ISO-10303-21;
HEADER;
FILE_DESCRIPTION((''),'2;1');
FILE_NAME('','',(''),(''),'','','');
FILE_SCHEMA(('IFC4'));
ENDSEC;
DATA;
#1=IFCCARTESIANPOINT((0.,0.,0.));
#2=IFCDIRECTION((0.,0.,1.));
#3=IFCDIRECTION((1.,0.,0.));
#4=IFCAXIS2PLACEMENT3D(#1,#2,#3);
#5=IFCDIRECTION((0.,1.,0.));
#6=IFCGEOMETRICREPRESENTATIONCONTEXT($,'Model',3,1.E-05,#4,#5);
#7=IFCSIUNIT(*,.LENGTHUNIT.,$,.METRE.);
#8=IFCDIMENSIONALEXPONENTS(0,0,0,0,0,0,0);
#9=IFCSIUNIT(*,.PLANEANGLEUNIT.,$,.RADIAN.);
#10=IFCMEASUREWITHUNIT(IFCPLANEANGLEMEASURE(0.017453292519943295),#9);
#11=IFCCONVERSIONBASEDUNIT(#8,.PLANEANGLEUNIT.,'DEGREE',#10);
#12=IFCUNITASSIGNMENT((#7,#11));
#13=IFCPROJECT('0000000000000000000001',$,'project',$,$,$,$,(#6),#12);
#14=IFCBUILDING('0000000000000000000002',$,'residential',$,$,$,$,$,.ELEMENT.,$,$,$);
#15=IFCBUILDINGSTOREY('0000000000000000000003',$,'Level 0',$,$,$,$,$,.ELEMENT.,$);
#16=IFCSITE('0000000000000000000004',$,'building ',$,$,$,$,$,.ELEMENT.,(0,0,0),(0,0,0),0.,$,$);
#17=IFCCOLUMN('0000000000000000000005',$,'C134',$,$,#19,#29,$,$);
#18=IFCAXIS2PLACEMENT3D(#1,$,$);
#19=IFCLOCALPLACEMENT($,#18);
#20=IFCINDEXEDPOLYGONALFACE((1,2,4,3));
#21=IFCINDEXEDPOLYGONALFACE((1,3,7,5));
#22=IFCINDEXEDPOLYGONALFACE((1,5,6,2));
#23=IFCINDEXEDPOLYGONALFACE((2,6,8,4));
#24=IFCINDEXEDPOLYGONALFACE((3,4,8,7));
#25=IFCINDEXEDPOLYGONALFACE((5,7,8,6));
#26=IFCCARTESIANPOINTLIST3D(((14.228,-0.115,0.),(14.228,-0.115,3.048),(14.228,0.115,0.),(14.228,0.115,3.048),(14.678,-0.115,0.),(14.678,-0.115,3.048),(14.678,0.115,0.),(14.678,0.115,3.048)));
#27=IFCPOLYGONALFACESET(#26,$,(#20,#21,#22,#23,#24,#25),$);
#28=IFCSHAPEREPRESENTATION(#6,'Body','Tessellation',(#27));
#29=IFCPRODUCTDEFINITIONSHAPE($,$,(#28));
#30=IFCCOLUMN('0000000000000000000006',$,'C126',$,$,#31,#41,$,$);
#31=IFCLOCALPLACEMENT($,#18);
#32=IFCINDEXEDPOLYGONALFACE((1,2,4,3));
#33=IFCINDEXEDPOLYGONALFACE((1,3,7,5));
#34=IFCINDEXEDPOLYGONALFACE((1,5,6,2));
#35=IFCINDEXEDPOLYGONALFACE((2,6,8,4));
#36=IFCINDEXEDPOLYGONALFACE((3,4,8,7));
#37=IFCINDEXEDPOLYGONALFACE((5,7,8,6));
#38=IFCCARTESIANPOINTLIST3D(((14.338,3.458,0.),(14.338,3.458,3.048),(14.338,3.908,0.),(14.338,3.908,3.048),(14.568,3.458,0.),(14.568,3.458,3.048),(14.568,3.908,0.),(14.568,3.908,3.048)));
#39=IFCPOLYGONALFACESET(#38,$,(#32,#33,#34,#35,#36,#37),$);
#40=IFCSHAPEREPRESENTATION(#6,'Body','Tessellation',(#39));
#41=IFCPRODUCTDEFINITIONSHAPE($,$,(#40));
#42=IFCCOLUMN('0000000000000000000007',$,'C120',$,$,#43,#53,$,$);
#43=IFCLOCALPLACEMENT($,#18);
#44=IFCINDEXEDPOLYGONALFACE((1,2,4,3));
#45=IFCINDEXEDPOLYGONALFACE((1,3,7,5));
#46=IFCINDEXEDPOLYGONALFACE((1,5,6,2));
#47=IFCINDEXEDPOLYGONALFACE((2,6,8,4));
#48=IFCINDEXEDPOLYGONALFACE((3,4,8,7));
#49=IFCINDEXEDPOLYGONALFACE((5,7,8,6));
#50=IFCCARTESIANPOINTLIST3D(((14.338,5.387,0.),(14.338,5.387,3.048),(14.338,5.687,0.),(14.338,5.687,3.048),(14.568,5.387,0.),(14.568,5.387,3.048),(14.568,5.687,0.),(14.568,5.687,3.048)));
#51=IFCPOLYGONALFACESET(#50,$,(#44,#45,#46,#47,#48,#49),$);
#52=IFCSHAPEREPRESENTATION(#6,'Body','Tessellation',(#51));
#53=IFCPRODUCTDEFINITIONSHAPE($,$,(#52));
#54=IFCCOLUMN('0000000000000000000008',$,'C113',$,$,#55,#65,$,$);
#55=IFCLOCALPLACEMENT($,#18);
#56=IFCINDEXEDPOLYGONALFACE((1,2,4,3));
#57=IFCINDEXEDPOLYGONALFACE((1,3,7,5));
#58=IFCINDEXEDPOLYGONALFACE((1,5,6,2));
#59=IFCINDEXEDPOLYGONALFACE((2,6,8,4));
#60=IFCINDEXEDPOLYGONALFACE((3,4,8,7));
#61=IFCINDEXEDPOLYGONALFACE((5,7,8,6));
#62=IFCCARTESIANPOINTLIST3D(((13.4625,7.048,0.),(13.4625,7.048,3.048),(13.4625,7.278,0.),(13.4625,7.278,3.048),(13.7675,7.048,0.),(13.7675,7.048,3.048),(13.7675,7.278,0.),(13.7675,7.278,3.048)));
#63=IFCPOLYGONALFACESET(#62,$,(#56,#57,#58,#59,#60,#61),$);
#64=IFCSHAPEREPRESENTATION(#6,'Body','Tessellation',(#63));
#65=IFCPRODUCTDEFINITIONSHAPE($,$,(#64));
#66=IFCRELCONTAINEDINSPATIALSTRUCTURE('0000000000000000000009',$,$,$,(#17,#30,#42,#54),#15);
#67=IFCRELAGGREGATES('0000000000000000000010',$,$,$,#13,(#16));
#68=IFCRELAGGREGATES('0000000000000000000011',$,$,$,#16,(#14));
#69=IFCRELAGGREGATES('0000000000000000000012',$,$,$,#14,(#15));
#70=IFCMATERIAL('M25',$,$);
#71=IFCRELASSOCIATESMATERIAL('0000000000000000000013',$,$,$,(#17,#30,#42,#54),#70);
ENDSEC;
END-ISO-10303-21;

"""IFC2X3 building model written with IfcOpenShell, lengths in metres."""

from ifc_helpers import new_model, entity, si_unit, converted_unit, direction, frame, frame_2d, origin_with_axes, place, context, project, spatial, rectangle, extrude, material, element, save


model = new_model("IFC2X3")

# Units and contexts
model_context = context("Model", 3, precision=1e-05, world=origin_with_axes(), true_north=direction((0.0, 1.0, 0.0)))
ifc_project = project(units=[si_unit("LENGTHUNIT", "METRE"), converted_unit("PLANEANGLEUNIT", "DEGREE", entity("IfcPlaneAngleMeasure", 0.017453292519943295), si_unit("PLANEANGLEUNIT", "RADIAN"), dimensions=[0, 0, 0, 0, 0, 0, 0])], contexts=[model_context])

# Site, building, storey
site = spatial("IfcSite", under=ifc_project, Name="building ", CompositionType="ELEMENT", RefLatitude=(0, 0, 0), RefLongitude=(0, 0, 0), RefElevation=0.0)
building = spatial("IfcBuilding", under=site, Name="residential", CompositionType="ELEMENT")
storey = spatial("IfcBuildingStorey", under=building, Name="Level 0", CompositionType="ELEMENT")

# Columns
ifc_material = material(Name="M25")
placement = place(None, origin_with_axes())
element("IfcColumn", 1, at=placement, inside=storey, material=ifc_material, Name="C134", context=model_context, shape_type="SweptSolid", body=[
    extrude(rectangle(XDim=0.45, YDim=0.23, at=frame_2d((0.0, 0.0), x_axis=(1.0, 0.0, 0.0))), frame((14.453, 0.0, 0.0), z_axis=(0.0, 0.0, 1.0), x_axis=(1.0, 0.0, 0.0)), (0.0, 0.0, 1.0), 3.048),
])
element("IfcColumn", 2, at=placement, inside=storey, material=ifc_material, Name="C126", context=model_context, shape_type="SweptSolid", body=[
    extrude(rectangle(XDim=0.23, YDim=0.45, at=frame_2d((0.0, 0.0), x_axis=(1.0, 0.0, 0.0))), frame((14.453, 3.683, 0.0), z_axis=(0.0, 0.0, 1.0), x_axis=(1.0, 0.0, 0.0)), (0.0, 0.0, 1.0), 3.048),
])
element("IfcColumn", 3, at=placement, inside=storey, material=ifc_material, Name="C120", context=model_context, shape_type="SweptSolid", body=[
    extrude(rectangle(XDim=0.23, YDim=0.3, at=frame_2d((0.0, 0.0), x_axis=(1.0, 0.0, 0.0))), frame((14.453, 5.537, 0.0), z_axis=(0.0, 0.0, 1.0), x_axis=(1.0, 0.0, 0.0)), (0.0, 0.0, 1.0), 3.048),
])
element("IfcColumn", 4, at=placement, inside=storey, material=ifc_material, Name="C113", context=model_context, shape_type="SweptSolid", body=[
    extrude(rectangle(XDim=0.305, YDim=0.23, at=frame_2d((0.0, 0.0), x_axis=(1.0, 0.0, 0.0))), frame((13.615, 7.163, 0.0), z_axis=(0.0, 0.0, 1.0), x_axis=(1.0, 0.0, 0.0)), (0.0, 0.0, 1.0), 3.048),
])

save(model, "model.ifc")
